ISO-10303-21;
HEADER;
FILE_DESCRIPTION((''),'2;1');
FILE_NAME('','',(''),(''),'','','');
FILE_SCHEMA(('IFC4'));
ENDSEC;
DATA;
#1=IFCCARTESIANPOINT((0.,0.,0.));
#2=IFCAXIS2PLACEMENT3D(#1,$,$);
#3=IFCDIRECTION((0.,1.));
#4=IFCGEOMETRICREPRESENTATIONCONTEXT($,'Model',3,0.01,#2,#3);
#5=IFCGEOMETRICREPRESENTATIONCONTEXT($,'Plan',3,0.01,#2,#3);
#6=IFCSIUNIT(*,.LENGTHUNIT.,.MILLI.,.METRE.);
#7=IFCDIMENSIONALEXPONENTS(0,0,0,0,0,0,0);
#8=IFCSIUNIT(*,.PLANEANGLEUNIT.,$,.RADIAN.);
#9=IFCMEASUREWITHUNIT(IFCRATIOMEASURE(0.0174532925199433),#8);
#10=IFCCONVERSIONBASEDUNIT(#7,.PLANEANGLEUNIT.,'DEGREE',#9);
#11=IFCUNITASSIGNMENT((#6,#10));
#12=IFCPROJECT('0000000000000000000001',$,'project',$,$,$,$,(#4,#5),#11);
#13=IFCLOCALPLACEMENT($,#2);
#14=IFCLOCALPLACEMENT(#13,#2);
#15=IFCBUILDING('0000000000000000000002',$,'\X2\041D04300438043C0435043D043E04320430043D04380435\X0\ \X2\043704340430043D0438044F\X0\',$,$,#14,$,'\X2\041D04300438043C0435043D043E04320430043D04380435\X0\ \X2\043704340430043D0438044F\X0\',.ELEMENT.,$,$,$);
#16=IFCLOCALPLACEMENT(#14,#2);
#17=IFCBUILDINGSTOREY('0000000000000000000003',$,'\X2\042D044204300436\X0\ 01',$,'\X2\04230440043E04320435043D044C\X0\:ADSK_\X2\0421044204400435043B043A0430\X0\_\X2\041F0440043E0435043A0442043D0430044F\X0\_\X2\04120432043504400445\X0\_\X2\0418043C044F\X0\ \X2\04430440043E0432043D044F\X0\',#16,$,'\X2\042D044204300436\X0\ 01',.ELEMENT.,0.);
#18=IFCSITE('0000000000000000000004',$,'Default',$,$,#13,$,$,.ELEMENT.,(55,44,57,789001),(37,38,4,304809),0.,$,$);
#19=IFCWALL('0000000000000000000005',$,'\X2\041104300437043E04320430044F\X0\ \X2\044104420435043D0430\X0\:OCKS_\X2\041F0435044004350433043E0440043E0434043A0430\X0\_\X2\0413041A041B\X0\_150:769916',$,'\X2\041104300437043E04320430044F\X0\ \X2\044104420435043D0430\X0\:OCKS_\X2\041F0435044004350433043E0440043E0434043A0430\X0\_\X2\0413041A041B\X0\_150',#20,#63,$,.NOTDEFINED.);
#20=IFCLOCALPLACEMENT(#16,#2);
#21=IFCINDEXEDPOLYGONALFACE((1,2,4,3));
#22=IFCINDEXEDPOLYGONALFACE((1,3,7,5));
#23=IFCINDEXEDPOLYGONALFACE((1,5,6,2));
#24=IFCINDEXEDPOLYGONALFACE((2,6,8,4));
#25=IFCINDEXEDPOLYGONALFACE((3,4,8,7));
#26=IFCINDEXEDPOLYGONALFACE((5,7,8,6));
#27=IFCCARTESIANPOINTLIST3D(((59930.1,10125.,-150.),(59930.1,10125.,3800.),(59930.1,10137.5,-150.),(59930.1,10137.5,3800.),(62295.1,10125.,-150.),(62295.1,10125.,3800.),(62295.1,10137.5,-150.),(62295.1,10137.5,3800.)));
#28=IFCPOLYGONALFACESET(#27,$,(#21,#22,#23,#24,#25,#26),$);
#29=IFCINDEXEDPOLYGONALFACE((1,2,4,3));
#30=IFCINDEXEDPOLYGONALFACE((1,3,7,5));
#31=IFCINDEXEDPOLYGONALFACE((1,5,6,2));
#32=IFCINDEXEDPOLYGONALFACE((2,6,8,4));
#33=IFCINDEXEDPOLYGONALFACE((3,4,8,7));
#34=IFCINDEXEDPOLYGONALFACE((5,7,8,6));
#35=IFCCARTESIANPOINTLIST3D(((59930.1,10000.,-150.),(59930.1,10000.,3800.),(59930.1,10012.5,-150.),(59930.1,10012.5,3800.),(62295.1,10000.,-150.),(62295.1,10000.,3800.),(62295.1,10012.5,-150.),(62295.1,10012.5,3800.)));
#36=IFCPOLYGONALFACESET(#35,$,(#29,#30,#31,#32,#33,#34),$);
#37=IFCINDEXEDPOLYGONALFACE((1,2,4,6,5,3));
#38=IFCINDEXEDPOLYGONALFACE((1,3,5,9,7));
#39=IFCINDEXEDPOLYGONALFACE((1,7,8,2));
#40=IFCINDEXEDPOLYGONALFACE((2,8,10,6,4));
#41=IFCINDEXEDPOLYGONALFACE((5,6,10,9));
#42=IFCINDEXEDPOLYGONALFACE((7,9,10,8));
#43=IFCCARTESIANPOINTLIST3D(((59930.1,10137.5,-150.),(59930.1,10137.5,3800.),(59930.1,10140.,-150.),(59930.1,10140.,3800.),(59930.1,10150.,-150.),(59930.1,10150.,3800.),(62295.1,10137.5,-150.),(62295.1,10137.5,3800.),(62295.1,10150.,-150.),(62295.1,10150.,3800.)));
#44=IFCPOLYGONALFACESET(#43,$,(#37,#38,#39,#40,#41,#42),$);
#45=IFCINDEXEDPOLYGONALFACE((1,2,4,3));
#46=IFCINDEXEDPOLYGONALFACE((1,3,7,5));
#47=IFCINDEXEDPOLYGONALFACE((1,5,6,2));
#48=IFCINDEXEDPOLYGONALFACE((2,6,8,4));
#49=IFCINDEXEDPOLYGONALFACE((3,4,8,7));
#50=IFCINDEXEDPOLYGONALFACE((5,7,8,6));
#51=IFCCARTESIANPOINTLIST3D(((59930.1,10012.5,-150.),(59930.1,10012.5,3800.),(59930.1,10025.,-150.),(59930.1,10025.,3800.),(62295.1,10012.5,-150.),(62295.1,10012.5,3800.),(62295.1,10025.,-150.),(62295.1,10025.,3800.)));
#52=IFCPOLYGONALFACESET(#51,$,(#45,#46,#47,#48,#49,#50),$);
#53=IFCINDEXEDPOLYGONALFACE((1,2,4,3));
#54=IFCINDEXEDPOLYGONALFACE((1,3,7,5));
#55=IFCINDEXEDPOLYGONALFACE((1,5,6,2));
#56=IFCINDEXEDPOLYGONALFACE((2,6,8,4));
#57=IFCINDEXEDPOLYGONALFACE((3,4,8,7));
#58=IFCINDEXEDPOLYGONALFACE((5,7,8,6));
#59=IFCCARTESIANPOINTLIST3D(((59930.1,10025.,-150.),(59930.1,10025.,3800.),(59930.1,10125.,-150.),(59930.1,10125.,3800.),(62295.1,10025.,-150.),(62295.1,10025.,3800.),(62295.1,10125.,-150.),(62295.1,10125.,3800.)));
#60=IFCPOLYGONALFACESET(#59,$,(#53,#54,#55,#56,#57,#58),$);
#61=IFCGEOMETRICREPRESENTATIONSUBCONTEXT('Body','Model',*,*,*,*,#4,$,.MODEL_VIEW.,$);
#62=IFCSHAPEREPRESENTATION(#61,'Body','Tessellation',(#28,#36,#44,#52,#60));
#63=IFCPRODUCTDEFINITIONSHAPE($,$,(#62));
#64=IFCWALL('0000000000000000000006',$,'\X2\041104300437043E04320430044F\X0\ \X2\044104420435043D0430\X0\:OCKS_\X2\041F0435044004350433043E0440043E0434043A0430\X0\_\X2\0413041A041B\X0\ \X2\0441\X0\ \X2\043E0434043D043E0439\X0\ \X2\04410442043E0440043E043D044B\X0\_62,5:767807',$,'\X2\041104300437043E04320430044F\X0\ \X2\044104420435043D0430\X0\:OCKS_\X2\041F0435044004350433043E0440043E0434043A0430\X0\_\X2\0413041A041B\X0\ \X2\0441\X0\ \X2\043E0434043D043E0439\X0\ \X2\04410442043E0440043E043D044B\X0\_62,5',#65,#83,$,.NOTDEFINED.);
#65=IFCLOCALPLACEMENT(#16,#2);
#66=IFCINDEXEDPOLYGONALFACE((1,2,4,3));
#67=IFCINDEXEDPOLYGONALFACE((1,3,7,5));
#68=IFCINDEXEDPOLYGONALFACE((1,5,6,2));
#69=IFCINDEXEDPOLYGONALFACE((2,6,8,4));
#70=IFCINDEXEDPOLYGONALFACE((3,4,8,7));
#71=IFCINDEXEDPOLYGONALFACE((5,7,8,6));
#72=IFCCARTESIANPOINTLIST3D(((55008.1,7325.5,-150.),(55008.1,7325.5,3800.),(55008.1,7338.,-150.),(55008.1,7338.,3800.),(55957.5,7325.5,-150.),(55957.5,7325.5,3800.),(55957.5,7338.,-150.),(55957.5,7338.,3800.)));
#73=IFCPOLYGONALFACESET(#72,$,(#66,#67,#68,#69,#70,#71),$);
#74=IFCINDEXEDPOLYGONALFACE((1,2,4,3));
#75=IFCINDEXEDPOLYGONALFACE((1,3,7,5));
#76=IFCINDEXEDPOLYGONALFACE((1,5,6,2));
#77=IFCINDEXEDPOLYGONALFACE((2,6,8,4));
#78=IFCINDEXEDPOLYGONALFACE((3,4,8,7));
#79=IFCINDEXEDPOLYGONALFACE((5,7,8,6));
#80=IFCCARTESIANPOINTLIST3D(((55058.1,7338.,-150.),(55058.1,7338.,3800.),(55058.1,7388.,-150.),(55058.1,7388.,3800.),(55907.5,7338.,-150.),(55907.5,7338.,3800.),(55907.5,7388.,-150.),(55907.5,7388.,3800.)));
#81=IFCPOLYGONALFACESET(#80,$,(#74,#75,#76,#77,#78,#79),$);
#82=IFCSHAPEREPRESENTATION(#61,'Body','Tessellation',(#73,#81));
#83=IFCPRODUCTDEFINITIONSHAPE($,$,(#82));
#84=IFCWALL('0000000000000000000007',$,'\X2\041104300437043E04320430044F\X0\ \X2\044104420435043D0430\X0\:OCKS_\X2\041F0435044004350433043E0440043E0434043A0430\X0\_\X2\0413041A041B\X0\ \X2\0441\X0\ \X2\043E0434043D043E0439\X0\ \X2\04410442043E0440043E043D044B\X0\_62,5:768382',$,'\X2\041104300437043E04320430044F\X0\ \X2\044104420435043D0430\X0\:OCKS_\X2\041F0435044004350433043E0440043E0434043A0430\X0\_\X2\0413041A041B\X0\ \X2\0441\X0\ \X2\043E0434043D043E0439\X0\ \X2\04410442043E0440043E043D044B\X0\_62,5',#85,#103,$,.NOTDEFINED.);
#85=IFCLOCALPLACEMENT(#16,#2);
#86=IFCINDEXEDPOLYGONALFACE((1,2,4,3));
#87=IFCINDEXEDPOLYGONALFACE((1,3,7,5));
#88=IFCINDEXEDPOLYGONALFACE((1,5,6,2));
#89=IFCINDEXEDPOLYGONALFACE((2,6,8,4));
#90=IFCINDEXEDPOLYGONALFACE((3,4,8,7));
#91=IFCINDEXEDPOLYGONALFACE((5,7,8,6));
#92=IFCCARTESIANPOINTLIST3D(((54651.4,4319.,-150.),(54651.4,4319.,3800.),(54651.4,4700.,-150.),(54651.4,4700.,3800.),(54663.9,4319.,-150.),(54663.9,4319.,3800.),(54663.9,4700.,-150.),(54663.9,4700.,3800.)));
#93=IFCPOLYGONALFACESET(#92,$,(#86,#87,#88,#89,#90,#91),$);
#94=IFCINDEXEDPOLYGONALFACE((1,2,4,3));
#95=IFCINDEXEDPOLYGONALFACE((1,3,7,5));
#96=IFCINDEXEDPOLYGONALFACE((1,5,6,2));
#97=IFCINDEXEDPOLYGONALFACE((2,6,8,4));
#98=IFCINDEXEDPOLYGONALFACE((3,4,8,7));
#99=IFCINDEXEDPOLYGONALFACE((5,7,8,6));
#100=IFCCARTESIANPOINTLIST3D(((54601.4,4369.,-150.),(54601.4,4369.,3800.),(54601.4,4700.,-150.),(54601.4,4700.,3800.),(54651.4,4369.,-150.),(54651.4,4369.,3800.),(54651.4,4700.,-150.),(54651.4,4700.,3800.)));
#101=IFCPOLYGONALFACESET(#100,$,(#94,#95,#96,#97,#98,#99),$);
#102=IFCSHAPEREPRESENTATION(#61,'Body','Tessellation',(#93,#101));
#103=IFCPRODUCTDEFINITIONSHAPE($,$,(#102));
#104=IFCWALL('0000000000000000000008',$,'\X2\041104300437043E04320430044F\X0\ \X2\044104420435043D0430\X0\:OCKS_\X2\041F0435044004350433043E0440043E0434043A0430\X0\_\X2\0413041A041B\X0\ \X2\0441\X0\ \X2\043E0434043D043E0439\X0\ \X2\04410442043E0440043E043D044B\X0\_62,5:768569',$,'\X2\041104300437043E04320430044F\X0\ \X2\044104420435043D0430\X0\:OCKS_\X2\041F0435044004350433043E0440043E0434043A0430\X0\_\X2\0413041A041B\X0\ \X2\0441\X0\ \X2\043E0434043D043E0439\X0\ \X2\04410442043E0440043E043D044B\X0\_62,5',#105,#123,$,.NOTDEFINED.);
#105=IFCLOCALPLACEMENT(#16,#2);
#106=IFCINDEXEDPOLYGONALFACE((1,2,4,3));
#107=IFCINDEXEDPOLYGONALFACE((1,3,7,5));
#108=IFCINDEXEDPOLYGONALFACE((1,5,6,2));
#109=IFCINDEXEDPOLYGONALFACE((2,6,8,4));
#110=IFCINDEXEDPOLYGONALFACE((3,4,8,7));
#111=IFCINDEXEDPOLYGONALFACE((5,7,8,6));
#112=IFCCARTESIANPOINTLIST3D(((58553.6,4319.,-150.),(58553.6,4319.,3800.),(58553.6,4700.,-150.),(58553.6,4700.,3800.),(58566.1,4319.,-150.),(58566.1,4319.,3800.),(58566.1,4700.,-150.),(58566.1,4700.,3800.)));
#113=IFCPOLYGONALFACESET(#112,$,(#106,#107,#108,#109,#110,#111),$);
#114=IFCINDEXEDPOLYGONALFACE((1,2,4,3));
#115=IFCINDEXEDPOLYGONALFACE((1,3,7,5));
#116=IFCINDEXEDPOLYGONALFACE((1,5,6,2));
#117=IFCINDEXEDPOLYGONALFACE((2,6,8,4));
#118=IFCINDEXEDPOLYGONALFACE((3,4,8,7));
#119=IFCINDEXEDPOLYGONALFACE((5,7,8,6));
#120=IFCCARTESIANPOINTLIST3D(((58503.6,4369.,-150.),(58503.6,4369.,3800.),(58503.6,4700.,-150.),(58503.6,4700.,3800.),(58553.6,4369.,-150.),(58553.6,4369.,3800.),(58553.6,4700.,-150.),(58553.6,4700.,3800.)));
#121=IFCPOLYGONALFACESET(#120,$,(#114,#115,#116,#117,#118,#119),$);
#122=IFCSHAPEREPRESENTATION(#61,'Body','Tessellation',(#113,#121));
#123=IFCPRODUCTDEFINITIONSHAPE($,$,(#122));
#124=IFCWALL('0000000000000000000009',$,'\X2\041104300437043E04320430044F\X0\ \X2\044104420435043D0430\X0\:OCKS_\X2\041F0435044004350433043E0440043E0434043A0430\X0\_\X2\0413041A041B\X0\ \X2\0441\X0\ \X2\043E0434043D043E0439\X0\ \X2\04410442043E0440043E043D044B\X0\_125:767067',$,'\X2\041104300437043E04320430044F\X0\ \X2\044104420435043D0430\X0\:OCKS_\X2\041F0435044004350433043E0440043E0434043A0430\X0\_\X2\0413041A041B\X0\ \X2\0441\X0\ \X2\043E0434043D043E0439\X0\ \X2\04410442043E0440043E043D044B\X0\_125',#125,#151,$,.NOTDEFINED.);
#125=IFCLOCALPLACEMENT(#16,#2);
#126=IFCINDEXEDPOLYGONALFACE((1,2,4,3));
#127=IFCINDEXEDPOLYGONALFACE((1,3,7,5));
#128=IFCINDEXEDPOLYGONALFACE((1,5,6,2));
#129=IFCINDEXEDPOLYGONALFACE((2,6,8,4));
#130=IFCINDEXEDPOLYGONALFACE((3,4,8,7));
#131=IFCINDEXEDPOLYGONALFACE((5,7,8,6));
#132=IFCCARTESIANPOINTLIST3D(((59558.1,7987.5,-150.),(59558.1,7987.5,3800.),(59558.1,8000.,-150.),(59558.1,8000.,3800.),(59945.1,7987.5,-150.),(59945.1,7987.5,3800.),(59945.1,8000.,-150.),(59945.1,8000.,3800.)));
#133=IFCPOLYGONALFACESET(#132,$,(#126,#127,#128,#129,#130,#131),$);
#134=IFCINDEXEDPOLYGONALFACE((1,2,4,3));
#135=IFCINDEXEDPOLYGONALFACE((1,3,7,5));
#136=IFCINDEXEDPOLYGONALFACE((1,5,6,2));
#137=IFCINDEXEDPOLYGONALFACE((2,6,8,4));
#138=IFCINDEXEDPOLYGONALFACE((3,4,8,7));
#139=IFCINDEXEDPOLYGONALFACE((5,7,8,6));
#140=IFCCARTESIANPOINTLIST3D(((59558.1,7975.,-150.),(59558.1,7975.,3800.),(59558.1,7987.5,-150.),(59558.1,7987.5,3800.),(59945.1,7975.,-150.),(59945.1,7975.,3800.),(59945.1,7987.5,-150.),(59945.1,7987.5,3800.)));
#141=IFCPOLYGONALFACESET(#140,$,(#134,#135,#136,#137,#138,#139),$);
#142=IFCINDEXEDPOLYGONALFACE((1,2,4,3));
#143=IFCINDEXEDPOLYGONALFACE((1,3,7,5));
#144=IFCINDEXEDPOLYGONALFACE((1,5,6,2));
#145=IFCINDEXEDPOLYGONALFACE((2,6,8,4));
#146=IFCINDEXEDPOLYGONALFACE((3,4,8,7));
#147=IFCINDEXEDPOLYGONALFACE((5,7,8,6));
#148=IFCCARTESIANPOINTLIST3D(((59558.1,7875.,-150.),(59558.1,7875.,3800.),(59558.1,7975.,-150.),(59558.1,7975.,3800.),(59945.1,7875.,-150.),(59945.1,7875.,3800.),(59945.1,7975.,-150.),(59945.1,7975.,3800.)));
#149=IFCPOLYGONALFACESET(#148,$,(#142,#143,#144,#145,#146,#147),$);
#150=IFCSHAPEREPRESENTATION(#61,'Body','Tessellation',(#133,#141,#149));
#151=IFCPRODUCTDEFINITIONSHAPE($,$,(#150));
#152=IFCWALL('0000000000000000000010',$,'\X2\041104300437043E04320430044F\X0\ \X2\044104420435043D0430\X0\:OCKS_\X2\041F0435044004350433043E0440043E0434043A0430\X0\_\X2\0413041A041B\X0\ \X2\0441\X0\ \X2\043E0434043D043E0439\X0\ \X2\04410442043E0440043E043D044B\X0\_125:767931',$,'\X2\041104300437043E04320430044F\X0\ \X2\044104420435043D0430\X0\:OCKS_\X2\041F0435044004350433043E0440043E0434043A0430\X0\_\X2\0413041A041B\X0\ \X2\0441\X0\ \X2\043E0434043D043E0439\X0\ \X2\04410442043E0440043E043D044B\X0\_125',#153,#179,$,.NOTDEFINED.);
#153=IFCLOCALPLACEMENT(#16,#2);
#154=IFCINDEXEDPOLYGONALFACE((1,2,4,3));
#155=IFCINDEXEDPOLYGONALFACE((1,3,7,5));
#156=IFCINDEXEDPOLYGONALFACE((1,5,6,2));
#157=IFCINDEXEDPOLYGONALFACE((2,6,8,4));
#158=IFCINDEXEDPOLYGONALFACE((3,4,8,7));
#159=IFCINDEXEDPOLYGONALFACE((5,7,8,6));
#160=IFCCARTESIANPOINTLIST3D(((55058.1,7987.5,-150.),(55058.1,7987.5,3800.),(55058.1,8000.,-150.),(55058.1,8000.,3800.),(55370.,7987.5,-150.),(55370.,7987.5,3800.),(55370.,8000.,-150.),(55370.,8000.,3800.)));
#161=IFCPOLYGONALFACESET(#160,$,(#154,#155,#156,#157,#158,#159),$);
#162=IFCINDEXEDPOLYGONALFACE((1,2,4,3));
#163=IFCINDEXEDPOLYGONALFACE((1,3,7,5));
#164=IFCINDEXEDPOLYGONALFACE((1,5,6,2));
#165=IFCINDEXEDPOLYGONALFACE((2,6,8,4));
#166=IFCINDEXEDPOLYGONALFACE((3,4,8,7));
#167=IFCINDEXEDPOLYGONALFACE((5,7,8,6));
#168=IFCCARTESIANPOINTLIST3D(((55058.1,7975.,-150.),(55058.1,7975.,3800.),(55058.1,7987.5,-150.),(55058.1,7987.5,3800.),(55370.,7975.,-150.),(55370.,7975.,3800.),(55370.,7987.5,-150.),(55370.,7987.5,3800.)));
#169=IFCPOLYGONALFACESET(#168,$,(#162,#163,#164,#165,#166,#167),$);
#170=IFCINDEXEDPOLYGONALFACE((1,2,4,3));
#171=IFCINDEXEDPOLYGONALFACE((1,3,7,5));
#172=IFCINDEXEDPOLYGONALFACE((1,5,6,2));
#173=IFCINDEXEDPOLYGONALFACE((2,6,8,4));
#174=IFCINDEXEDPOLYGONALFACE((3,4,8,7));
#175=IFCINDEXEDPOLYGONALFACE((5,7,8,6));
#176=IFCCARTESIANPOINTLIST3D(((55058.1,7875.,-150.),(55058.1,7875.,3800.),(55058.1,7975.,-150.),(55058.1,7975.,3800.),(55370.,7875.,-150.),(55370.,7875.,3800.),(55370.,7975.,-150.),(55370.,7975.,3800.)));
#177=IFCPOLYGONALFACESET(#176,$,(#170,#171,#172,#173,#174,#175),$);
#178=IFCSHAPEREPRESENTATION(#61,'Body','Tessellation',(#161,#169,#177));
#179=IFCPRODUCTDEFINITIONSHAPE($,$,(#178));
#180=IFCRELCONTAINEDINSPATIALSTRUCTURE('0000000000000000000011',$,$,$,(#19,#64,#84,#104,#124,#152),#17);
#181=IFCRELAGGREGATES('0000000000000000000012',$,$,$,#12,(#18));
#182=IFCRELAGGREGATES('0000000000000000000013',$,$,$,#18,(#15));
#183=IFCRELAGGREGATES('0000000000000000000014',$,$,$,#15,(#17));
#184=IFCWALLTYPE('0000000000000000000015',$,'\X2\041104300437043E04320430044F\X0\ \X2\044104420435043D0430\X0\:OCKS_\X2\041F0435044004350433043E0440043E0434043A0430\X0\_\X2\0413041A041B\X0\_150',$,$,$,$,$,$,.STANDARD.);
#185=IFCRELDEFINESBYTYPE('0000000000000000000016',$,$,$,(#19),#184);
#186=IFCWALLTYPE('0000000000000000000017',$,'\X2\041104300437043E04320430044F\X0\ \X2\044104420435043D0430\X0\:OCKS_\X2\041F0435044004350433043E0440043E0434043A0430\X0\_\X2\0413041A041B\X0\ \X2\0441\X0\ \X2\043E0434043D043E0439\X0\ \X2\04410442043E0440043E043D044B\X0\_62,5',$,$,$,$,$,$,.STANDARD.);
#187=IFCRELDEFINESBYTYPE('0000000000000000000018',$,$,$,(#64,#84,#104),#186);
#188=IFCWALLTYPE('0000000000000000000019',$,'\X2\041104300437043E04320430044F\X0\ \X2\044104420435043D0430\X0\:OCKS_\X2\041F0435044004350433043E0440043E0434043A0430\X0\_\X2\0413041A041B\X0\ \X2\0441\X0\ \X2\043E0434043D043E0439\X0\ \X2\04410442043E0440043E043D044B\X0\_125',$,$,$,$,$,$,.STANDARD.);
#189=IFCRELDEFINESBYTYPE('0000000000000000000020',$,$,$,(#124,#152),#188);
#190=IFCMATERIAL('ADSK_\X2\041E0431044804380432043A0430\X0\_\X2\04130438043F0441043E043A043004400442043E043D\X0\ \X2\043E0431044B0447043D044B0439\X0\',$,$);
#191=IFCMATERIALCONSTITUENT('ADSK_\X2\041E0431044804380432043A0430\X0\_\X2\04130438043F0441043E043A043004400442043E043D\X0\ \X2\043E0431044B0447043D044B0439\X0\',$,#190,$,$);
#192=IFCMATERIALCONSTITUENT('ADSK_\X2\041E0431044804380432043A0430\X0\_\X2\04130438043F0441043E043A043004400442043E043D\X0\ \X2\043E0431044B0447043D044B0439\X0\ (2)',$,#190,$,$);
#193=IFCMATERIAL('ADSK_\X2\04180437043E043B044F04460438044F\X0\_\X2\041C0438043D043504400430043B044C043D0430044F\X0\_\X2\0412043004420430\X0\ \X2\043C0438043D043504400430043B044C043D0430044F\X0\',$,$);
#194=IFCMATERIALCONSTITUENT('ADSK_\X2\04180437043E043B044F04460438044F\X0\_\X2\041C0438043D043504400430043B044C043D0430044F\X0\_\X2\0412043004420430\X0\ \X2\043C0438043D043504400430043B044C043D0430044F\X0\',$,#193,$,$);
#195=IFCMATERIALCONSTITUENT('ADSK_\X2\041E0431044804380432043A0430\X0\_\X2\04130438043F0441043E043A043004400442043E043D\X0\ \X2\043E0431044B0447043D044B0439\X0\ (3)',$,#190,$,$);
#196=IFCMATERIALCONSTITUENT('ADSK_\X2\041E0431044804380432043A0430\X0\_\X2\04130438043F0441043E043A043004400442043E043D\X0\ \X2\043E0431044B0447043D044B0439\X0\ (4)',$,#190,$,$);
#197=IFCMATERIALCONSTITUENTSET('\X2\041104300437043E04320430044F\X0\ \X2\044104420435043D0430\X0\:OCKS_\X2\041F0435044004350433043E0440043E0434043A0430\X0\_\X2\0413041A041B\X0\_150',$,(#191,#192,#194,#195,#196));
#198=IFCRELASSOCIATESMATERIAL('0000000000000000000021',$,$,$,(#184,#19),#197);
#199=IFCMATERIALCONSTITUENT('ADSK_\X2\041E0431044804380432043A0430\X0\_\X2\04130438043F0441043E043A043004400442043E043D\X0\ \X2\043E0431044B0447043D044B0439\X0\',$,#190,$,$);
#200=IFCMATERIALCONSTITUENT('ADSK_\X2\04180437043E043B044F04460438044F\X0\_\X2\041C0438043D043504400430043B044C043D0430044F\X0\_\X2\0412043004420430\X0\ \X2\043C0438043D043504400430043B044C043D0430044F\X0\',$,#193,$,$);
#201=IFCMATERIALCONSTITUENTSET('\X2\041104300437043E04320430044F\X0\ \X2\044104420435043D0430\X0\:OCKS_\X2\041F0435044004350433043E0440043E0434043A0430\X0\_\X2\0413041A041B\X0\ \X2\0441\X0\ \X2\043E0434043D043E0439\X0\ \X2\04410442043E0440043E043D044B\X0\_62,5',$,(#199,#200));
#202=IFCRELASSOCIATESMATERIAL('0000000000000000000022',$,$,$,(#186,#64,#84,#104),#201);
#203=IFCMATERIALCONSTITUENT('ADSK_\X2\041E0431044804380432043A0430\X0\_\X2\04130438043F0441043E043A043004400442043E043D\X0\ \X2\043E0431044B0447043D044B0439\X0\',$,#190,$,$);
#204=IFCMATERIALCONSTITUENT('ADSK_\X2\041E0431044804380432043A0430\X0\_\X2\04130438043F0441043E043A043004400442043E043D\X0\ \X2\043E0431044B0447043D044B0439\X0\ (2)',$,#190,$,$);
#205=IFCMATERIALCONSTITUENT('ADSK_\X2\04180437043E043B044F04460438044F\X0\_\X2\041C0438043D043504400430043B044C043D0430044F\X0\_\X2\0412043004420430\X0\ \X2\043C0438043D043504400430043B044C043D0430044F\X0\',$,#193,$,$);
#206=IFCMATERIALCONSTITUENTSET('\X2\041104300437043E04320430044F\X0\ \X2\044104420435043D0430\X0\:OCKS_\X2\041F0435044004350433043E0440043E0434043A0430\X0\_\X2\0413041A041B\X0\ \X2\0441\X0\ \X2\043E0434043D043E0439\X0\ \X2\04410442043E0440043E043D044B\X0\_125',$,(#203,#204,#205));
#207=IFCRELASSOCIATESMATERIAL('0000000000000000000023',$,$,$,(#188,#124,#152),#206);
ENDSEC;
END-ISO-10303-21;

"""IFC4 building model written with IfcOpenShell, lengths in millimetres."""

from ifc_helpers import new_model, entity, si_unit, converted_unit, direction, frame, origin, place, context, subcontext, project, spatial, indexed_curve, outline, extrude, material, constituent, constituent_set, type_object, element, save


model = new_model("IFC4")

# Units and contexts
model_context = context("Model", 3, precision=0.01, world=origin(), true_north=direction((0.0, 1.0)))
plan_context = context("Plan", 3, precision=0.01, world=origin(), true_north=direction((0.0, 1.0)))
body_context = subcontext(model_context, "Body", "Model", "MODEL_VIEW")
ifc_project = project(units=[si_unit("LENGTHUNIT", "METRE", prefix="MILLI"), converted_unit("PLANEANGLEUNIT", "DEGREE", entity("IfcRatioMeasure", 0.0174532925199433), si_unit("PLANEANGLEUNIT", "RADIAN"), dimensions=[0, 0, 0, 0, 0, 0, 0])], contexts=[model_context, plan_context])

# Site, building, storey
site_placement = place(None, frame((0.0, 0.0, 0.0)))
site = spatial("IfcSite", under=ifc_project, at=site_placement, Name="Default", CompositionType="ELEMENT", RefLatitude=(55, 44, 57, 789001), RefLongitude=(37, 38, 4, 304809), RefElevation=0.0)
building_placement = place(site_placement, origin())
building = spatial("IfcBuilding", under=site, at=building_placement, Name="Наименование здания", LongName="Наименование здания", CompositionType="ELEMENT")
storey_placement = place(building_placement, origin())
storey = spatial("IfcBuildingStorey", under=building, at=storey_placement, Name="Этаж 01", ObjectType="Уровень:ADSK_Стрелка_Проектная_Вверх_Имя уровня", LongName="Этаж 01", CompositionType="ELEMENT", Elevation=0.0)

# Shared definitions
ifc_material_1 = material(Name="ADSK_Обшивка_Гипсокартон обычный")
ifc_constituent_1 = constituent(ifc_material_1, Name="ADSK_Обшивка_Гипсокартон обычный")
ifc_constituent_2 = constituent(ifc_material_1, Name="ADSK_Обшивка_Гипсокартон обычный (2)")
ifc_material_2 = material(Name="ADSK_Изоляция_Минеральная_Вата минеральная")
ifc_constituent_3 = constituent(ifc_material_2, Name="ADSK_Изоляция_Минеральная_Вата минеральная")
ifc_constituent_4 = constituent(ifc_material_1, Name="ADSK_Обшивка_Гипсокартон обычный (3)")
ifc_constituent_5 = constituent(ifc_material_1, Name="ADSK_Обшивка_Гипсокартон обычный (4)")
ifc_constituent_set_1 = constituent_set(constituents=[ifc_constituent_1, ifc_constituent_2, ifc_constituent_3, ifc_constituent_4, ifc_constituent_5], Name="Базовая стена:OCKS_Перегородка_ГКЛ_150")
wall_type_1 = type_object("IfcWallType", Name="Базовая стена:OCKS_Перегородка_ГКЛ_150", PredefinedType="STANDARD", material=ifc_constituent_set_1)

# Wall
wall_1_placement = place(storey_placement, frame((59930.1, 10075.0, -150.0)))
element("IfcWall", 1, at=wall_1_placement, inside=storey, type_object=wall_type_1, material=ifc_constituent_set_1, Name="Базовая стена:OCKS_Перегородка_ГКЛ_150:769916", ObjectType="Базовая стена:OCKS_Перегородка_ГКЛ_150", PredefinedType="NOTDEFINED", context=body_context, shape_type="SweptSolid", body=[
    extrude(outline(indexed_curve([(-1182.5, -6.3), (1182.5, -6.3), (1182.5, 6.2), (-1182.5, 6.3), (-1182.5, -6.3)], self_intersect=False)), frame((1182.5, 56.3, 0.0)), (0.0, 0.0, 1.0), 3950.0),
    extrude(outline(indexed_curve([(-6.3, -1182.5), (6.2, -1182.5), (6.3, 1182.5), (-6.2, 1182.5), (-6.3, -1182.5)], self_intersect=False)), frame((1182.5, -68.7, 0.0), z_axis=(0.0, 0.0, 1.0), x_axis=(0.0, 1.0, 0.0)), (0.0, 0.0, 1.0), 3950.0),
    extrude(outline(indexed_curve([(-7.0, -946.0), (3.0, -946.0), (5.5, -946.0), (5.5, 1419.0), (-7.0, 1419.0), (-7.0, -946.0)], self_intersect=False)), frame((946.0, 68.0, 0.0), z_axis=(0.0, 0.0, 1.0), x_axis=(0.0, -1.0, 0.0)), (0.0, 0.0, 1.0), 3950.0),
    extrude(outline(indexed_curve([(-1182.5, -6.3), (1182.5, -6.3), (1182.5, 6.2), (-1182.5, 6.2), (-1182.5, -6.3)], self_intersect=False)), frame((1182.5, -56.2, 0.0)), (0.0, 0.0, 1.0), 3950.0),
    extrude(outline(indexed_curve([(-1182.5, -50.0), (1182.5, -50.0), (1182.5, 50.0), (-1182.5, 50.0), (-1182.5, -50.0)], self_intersect=False)), frame((1182.5, 0.0, 0.0)), (0.0, 0.0, 1.0), 3950.0),
])

# Shared definitions
ifc_constituent_6 = constituent(ifc_material_1, Name="ADSK_Обшивка_Гипсокартон обычный")
ifc_constituent_7 = constituent(ifc_material_2, Name="ADSK_Изоляция_Минеральная_Вата минеральная")
ifc_constituent_set_2 = constituent_set(constituents=[ifc_constituent_6, ifc_constituent_7], Name="Базовая стена:OCKS_Перегородка_ГКЛ с одной стороны_62,5")
wall_type_2 = type_object("IfcWallType", Name="Базовая стена:OCKS_Перегородка_ГКЛ с одной стороны_62,5", PredefinedType="STANDARD", material=ifc_constituent_set_2)

# Walls
wall_2_placement = place(storey_placement, frame((55058.1, 7356.8, -150.0)))
element("IfcWall", 2, at=wall_2_placement, inside=storey, type_object=wall_type_2, material=ifc_constituent_set_2, Name="Базовая стена:OCKS_Перегородка_ГКЛ с одной стороны_62,5:767807", ObjectType="Базовая стена:OCKS_Перегородка_ГКЛ с одной стороны_62,5", PredefinedType="NOTDEFINED", context=body_context, shape_type="SweptSolid", body=[
    extrude(outline(indexed_curve([(-6.3, -474.7), (6.2, -474.7), (6.3, 474.7), (-6.2, 474.7), (-6.3, -474.7)], self_intersect=False)), frame((424.7, -25.0, 0.0), z_axis=(0.0, 0.0, 1.0), x_axis=(0.0, 1.0, 0.0)), (0.0, 0.0, 1.0), 3950.0),
    extrude(outline(indexed_curve([(-25.0, -424.7), (25.0, -424.7), (25.0, 424.7), (-25.0, 424.7), (-25.0, -424.7)], self_intersect=False)), frame((424.7, 6.2, 0.0), z_axis=(0.0, 0.0, 1.0), x_axis=(0.0, -1.0, 0.0)), (0.0, 0.0, 1.0), 3950.0),
])
wall_3_placement = place(storey_placement, frame((54632.7, 4369.0, -150.0), z_axis=(0.0, 0.0, 1.0), x_axis=(0.0, 1.0, 0.0)))
element("IfcWall", 3, at=wall_3_placement, inside=storey, type_object=wall_type_2, material=ifc_constituent_set_2, Name="Базовая стена:OCKS_Перегородка_ГКЛ с одной стороны_62,5:768382", ObjectType="Базовая стена:OCKS_Перегородка_ГКЛ с одной стороны_62,5", PredefinedType="NOTDEFINED", context=body_context, shape_type="SweptSolid", body=[
    extrude(outline(indexed_curve([(-6.3, -190.5), (6.3, -190.5), (6.3, 190.5), (-6.3, 190.5), (-6.3, -190.5)], self_intersect=False)), frame((140.5, -25.0, 0.0), z_axis=(0.0, 0.0, 1.0), x_axis=(0.0, -1.0, 0.0)), (0.0, 0.0, 1.0), 3950.0),
    extrude(outline(indexed_curve([(-25.0, -165.5), (25.0, -165.5), (25.0, 165.5), (-25.0, 165.5), (-25.0, -165.5)], self_intersect=False)), frame((165.5, 6.3, 0.0), z_axis=(0.0, 0.0, 1.0), x_axis=(0.0, 1.0, 0.0)), (0.0, 0.0, 1.0), 3950.0),
])
wall_4_placement = place(storey_placement, frame((58534.8, 4369.0, -150.0), z_axis=(0.0, 0.0, 1.0), x_axis=(0.0, 1.0, 0.0)))
element("IfcWall", 4, at=wall_4_placement, inside=storey, type_object=wall_type_2, material=ifc_constituent_set_2, Name="Базовая стена:OCKS_Перегородка_ГКЛ с одной стороны_62,5:768569", ObjectType="Базовая стена:OCKS_Перегородка_ГКЛ с одной стороны_62,5", PredefinedType="NOTDEFINED", context=body_context, shape_type="SweptSolid", body=[
    extrude(outline(indexed_curve([(-6.3, -190.5), (6.3, -190.5), (6.3, 190.5), (-6.3, 190.5), (-6.3, -190.5)], self_intersect=False)), frame((140.5, -25.0, 0.0), z_axis=(0.0, 0.0, 1.0), x_axis=(0.0, -1.0, 0.0)), (0.0, 0.0, 1.0), 3950.0),
    extrude(outline(indexed_curve([(-25.0, -165.5), (25.0, -165.5), (25.0, 165.5), (-25.0, 165.5), (-25.0, -165.5)], self_intersect=False)), frame((165.5, 6.3, 0.0), z_axis=(0.0, 0.0, 1.0), x_axis=(0.0, 1.0, 0.0)), (0.0, 0.0, 1.0), 3950.0),
])
ifc_constituent_8 = constituent(ifc_material_1, Name="ADSK_Обшивка_Гипсокартон обычный")
ifc_constituent_9 = constituent(ifc_material_1, Name="ADSK_Обшивка_Гипсокартон обычный (2)")
ifc_constituent_10 = constituent(ifc_material_2, Name="ADSK_Изоляция_Минеральная_Вата минеральная")
ifc_constituent_set_3 = constituent_set(constituents=[ifc_constituent_8, ifc_constituent_9, ifc_constituent_10], Name="Базовая стена:OCKS_Перегородка_ГКЛ с одной стороны_125")
wall_type_3 = type_object("IfcWallType", Name="Базовая стена:OCKS_Перегородка_ГКЛ с одной стороны_125", PredefinedType="STANDARD", material=ifc_constituent_set_3)
wall_5_placement = place(storey_placement, frame((59945.1, 7937.5, -150.0), z_axis=(0.0, 0.0, 1.0), x_axis=(-1.0, 0.0, 0.0)))
element("IfcWall", 5, at=wall_5_placement, inside=storey, type_object=wall_type_3, material=ifc_constituent_set_3, Name="Базовая стена:OCKS_Перегородка_ГКЛ с одной стороны_125:767067", ObjectType="Базовая стена:OCKS_Перегородка_ГКЛ с одной стороны_125", PredefinedType="NOTDEFINED", context=body_context, shape_type="SweptSolid", body=[
    extrude(outline(indexed_curve([(-6.2, -193.5), (6.3, -193.5), (6.3, 193.5), (-6.2, 193.5), (-6.2, -193.5)], self_intersect=False)), frame((193.5, -56.3, 0.0), z_axis=(0.0, 0.0, 1.0), x_axis=(0.0, 1.0, 0.0)), (0.0, 0.0, 1.0), 3950.0),
    extrude(outline(indexed_curve([(-193.5, -6.2), (193.5, -6.2), (193.5, 6.3), (-193.5, 6.3), (-193.5, -6.2)], self_intersect=False)), frame((193.5, -43.8, 0.0)), (0.0, 0.0, 1.0), 3950.0),
    extrude(outline(indexed_curve([(-50.0, -193.5), (50.0, -193.5), (50.0, 193.5), (-50.0, 193.5), (-50.0, -193.5)], self_intersect=False)), frame((193.5, 12.5, 0.0), z_axis=(0.0, 0.0, 1.0), x_axis=(0.0, -1.0, 0.0)), (0.0, 0.0, 1.0), 3950.0),
])
wall_6_placement = place(storey_placement, frame((55058.1, 7937.5, -150.0)))
element("IfcWall", 6, at=wall_6_placement, inside=storey, type_object=wall_type_3, material=ifc_constituent_set_3, Name="Базовая стена:OCKS_Перегородка_ГКЛ с одной стороны_125:767931", ObjectType="Базовая стена:OCKS_Перегородка_ГКЛ с одной стороны_125", PredefinedType="NOTDEFINED", context=body_context, shape_type="SweptSolid", body=[
    extrude(outline(indexed_curve([(-6.2, -155.9), (6.3, -155.9), (6.3, 155.9), (-6.2, 155.9), (-6.2, -155.9)], self_intersect=False)), frame((155.9, 56.3, 0.0), z_axis=(0.0, 0.0, 1.0), x_axis=(0.0, -1.0, 0.0)), (0.0, 0.0, 1.0), 3950.0),
    extrude(outline(indexed_curve([(-155.9, -6.3), (155.9, -6.3), (155.9, 6.2), (-155.9, 6.2), (-155.9, -6.3)], self_intersect=False)), frame((155.9, 43.7, 0.0)), (0.0, 0.0, 1.0), 3950.0),
    extrude(outline(indexed_curve([(-50.0, -155.9), (50.0, -155.9), (50.0, 155.9), (-50.0, 155.9), (-50.0, -155.9)], self_intersect=False)), frame((155.9, -12.5, 0.0), z_axis=(0.0, 0.0, 1.0), x_axis=(0.0, 1.0, 0.0)), (0.0, 0.0, 1.0), 3950.0),
])

save(model, "model.ifc")
